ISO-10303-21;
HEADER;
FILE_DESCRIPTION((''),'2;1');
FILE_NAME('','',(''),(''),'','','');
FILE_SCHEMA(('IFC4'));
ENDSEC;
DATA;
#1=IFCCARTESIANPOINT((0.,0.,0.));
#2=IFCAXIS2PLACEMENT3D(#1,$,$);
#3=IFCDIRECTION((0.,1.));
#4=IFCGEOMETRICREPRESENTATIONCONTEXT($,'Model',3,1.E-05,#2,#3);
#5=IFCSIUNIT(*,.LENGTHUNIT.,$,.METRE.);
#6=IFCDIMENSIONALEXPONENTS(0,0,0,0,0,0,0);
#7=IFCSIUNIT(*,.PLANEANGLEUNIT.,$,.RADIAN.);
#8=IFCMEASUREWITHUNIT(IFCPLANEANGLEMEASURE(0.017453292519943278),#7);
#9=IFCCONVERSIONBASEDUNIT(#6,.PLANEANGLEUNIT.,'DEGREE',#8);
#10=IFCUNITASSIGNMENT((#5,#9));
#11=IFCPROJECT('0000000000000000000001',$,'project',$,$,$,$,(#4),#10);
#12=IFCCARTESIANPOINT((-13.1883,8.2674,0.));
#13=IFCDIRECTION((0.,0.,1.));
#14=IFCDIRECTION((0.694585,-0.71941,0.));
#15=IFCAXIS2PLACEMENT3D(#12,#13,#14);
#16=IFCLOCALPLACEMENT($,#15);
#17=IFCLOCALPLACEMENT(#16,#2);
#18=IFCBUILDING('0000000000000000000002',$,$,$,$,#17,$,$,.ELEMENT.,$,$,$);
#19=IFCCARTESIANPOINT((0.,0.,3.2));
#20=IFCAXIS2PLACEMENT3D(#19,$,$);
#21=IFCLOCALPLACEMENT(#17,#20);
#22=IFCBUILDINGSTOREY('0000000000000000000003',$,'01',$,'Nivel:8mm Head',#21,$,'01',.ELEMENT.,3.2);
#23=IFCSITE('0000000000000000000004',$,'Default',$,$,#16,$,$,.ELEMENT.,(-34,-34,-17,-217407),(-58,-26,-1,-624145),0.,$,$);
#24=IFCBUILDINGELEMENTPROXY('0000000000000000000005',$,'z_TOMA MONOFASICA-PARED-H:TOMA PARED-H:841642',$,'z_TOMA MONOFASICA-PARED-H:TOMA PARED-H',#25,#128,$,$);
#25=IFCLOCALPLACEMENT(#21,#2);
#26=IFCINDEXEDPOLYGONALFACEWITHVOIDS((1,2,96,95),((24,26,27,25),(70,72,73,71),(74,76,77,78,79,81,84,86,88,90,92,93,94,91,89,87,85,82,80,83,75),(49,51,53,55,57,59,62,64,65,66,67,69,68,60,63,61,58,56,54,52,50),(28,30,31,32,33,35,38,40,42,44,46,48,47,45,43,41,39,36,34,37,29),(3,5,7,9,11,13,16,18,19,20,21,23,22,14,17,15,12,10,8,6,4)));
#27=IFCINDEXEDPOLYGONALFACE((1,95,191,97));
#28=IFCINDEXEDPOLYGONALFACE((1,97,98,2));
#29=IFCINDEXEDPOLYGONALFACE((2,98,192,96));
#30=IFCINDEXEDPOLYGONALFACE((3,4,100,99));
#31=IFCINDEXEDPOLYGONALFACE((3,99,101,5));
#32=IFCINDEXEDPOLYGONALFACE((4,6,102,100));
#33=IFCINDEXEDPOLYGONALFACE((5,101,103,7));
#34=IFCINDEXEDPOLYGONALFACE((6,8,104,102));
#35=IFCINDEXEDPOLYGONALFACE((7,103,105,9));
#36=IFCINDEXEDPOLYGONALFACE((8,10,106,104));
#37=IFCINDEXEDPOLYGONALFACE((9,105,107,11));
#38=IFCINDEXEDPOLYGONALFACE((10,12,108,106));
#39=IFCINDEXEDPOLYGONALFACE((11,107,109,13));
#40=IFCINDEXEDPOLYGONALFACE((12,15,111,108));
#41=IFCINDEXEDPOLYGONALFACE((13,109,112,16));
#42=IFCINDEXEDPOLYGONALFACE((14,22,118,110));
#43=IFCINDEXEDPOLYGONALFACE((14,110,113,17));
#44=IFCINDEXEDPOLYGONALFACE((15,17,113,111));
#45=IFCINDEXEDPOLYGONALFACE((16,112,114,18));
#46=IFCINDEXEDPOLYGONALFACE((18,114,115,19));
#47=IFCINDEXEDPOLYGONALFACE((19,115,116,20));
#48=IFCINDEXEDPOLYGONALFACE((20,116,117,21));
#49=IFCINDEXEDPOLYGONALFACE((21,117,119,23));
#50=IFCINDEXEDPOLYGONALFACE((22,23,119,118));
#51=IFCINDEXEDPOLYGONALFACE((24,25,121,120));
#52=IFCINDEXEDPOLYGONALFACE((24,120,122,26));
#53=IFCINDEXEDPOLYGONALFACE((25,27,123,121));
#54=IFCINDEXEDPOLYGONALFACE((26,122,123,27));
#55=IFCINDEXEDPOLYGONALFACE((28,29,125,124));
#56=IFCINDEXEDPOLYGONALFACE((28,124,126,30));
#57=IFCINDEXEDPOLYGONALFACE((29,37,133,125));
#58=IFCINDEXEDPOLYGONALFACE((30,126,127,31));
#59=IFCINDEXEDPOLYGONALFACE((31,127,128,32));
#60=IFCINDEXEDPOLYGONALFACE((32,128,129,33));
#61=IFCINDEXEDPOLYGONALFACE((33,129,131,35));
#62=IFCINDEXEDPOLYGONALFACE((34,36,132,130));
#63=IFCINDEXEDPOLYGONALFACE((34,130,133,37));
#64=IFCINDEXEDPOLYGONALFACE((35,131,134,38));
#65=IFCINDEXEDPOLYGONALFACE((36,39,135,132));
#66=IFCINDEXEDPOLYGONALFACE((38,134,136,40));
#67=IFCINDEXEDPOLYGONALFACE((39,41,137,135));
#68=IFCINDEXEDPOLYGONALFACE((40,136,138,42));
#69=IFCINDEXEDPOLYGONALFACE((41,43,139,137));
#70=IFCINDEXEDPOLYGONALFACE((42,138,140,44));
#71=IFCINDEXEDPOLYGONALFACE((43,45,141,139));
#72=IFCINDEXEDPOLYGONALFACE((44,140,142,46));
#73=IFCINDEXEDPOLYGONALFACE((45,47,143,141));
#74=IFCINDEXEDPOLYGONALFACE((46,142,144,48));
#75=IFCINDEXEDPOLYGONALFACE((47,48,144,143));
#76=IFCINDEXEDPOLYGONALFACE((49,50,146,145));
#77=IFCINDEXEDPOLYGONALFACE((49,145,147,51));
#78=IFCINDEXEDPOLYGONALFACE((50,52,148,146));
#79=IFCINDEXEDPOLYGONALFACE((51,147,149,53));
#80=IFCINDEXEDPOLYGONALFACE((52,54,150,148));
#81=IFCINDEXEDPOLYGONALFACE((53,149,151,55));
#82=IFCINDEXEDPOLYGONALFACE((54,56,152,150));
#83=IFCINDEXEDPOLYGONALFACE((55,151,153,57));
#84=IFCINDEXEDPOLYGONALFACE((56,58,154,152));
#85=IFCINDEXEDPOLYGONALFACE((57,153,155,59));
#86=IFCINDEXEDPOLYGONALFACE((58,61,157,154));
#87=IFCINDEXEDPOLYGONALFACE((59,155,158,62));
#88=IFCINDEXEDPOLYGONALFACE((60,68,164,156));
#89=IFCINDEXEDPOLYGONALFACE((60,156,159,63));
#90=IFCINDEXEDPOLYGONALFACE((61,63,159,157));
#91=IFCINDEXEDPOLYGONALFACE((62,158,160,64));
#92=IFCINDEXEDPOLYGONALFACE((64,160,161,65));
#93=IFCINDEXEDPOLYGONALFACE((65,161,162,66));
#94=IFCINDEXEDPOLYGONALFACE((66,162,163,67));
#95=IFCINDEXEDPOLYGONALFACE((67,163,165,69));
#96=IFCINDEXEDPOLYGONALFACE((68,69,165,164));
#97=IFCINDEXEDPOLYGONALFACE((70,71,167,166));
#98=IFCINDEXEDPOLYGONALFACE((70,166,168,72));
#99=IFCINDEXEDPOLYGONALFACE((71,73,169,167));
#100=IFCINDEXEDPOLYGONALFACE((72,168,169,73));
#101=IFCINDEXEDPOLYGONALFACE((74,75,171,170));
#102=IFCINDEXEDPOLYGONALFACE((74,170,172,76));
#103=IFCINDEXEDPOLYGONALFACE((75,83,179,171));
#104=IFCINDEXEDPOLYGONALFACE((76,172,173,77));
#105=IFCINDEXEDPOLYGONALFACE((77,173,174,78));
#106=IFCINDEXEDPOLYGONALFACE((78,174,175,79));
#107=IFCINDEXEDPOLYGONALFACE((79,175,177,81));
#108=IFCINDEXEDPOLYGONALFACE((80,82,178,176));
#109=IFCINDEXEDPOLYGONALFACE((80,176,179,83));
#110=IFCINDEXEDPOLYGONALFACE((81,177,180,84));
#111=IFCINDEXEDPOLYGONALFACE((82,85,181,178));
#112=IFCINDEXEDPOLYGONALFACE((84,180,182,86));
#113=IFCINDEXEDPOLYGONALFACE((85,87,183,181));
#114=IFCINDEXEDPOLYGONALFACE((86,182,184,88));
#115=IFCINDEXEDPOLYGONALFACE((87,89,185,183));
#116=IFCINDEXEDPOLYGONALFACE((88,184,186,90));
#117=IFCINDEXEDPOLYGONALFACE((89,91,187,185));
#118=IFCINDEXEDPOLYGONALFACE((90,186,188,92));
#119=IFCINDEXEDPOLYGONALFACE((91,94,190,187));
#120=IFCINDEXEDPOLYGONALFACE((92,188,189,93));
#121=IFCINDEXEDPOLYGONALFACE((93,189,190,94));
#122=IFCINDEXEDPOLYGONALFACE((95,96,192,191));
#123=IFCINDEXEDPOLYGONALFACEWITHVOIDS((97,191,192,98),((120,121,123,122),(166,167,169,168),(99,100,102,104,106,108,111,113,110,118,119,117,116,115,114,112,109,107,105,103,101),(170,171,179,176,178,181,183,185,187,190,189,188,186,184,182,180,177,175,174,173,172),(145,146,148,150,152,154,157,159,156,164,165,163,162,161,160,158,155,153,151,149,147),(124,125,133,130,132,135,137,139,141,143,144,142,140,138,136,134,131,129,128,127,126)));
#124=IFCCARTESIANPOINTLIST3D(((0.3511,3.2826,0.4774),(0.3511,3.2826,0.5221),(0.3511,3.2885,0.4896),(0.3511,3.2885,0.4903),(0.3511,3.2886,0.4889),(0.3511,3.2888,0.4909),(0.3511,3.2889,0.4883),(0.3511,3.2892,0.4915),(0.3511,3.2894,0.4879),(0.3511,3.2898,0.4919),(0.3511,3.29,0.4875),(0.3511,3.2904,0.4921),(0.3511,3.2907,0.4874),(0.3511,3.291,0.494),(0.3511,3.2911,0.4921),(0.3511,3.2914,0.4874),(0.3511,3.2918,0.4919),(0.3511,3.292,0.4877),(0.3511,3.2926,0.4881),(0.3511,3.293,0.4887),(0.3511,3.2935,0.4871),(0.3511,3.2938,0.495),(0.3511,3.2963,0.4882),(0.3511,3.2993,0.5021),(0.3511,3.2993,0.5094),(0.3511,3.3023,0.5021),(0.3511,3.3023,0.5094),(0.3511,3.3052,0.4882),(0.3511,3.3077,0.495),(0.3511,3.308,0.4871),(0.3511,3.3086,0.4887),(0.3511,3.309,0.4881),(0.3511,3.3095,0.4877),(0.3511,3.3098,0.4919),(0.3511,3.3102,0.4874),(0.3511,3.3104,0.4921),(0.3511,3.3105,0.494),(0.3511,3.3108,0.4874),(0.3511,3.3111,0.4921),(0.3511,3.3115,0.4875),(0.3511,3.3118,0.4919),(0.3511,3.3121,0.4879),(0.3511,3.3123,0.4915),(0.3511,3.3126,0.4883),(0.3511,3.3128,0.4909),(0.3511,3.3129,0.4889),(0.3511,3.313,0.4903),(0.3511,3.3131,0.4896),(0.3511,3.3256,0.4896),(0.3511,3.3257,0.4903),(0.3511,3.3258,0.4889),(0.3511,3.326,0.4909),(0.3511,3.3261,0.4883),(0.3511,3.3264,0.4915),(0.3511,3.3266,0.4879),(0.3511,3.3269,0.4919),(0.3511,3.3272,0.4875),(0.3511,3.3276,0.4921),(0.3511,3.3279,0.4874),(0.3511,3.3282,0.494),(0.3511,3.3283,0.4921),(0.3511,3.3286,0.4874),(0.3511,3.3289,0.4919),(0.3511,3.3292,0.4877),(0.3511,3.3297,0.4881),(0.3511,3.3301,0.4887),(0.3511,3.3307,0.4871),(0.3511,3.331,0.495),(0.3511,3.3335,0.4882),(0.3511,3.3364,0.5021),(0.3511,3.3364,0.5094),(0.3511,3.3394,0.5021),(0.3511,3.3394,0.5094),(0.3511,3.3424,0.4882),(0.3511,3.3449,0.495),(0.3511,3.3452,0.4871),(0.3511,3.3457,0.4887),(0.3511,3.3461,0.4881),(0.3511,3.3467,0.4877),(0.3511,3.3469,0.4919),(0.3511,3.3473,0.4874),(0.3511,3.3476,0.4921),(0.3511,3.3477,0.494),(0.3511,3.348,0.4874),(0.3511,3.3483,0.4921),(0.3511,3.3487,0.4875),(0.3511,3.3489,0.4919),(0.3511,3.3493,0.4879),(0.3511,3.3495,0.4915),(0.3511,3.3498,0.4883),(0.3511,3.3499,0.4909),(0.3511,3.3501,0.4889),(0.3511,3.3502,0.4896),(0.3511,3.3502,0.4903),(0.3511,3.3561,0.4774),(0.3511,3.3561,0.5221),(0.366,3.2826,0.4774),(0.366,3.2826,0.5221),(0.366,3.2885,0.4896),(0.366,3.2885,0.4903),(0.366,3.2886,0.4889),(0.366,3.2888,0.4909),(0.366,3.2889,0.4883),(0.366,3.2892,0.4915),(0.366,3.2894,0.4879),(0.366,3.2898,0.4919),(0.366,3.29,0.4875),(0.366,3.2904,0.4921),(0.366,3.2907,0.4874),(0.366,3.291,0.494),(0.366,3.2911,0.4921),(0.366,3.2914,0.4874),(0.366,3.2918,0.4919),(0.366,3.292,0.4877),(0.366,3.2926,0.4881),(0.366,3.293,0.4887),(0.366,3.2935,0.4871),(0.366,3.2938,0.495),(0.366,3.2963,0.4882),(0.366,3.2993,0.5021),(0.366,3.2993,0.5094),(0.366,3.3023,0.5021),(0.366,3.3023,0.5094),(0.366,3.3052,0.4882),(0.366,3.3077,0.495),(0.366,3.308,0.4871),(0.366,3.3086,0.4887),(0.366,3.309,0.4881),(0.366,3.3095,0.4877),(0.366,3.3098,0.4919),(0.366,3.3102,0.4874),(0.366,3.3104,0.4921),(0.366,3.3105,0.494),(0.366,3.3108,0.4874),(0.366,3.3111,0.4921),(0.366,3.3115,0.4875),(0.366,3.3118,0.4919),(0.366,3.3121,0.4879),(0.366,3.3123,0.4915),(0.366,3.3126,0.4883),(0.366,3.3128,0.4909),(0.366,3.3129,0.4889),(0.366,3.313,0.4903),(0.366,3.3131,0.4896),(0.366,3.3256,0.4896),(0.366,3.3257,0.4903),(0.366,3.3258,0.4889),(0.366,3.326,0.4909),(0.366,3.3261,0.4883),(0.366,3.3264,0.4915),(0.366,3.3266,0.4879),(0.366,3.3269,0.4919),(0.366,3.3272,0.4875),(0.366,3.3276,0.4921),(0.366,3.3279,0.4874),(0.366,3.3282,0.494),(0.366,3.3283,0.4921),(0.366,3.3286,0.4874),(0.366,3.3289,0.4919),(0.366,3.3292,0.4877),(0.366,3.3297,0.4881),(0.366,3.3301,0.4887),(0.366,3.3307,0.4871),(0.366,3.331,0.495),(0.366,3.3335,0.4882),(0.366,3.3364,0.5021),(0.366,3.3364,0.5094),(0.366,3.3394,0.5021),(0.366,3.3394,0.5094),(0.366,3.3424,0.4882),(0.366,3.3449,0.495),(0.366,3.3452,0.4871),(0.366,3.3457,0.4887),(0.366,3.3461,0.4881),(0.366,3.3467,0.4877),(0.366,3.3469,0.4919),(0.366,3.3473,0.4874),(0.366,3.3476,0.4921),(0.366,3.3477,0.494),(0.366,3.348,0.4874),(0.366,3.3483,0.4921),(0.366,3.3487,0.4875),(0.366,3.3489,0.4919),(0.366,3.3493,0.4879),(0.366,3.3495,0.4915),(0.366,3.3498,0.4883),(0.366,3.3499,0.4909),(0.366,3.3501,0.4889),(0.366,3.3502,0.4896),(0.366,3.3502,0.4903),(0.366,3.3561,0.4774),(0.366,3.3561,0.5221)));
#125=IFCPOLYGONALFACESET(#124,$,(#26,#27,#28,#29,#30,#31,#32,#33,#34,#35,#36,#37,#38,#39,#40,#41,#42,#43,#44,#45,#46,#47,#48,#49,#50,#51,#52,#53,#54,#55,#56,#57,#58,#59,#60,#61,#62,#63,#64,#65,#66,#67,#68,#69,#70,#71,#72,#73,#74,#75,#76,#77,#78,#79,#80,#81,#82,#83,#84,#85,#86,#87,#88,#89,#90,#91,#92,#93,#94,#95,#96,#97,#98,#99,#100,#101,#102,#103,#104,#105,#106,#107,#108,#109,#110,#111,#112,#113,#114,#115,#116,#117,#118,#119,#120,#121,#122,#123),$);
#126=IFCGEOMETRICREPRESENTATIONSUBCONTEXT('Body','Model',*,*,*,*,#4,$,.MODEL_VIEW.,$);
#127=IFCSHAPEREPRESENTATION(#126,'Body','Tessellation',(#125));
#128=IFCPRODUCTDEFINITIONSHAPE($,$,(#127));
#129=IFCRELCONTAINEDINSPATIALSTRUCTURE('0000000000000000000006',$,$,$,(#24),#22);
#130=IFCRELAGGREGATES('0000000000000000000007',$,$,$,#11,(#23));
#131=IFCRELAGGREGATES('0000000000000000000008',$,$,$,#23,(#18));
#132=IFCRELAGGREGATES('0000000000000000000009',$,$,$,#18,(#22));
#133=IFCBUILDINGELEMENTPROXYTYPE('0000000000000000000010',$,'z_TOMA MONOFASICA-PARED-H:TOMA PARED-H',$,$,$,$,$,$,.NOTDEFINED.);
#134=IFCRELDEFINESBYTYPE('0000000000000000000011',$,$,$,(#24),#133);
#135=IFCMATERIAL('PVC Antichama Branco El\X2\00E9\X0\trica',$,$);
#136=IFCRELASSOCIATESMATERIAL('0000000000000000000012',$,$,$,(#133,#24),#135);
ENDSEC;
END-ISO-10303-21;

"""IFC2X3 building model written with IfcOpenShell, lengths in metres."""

from ifc_helpers import new_model, entity, si_unit, converted_unit, direction, frame, frame_2d, origin, place, context, subcontext, project, spatial, polyline, circle_curve, parameter, trimmed, segment, composite_curve, outline, extrude, source, transform, mapped, material, type_object, type_shapes, element, save


model = new_model("IFC2X3")

# Units and contexts
model_context = context("Model", 3, precision=1e-05, world=origin(), true_north=direction((0.0, 1.0)))
body_context = subcontext(model_context, "Body", "Model", "MODEL_VIEW")
ifc_project = project(units=[si_unit("LENGTHUNIT", "METRE"), converted_unit("PLANEANGLEUNIT", "DEGREE", entity("IfcPlaneAngleMeasure", 0.017453292519943278), si_unit("PLANEANGLEUNIT", "RADIAN"), dimensions=[0, 0, 0, 0, 0, 0, 0])], contexts=[model_context])

# Site, building, storey
site_placement = place(None, frame((-13.1883, 8.2674, 0.0), z_axis=(0.0, 0.0, 1.0), x_axis=(0.694585, -0.71941, 0.0)))
site = spatial("IfcSite", under=ifc_project, at=site_placement, Name="Default", CompositionType="ELEMENT", RefLatitude=(-34, -34, -17, -217407), RefLongitude=(-58, -26, -1, -624145), RefElevation=0.0)
building_placement = place(site_placement, origin())
building = spatial("IfcBuilding", under=site, at=building_placement, CompositionType="ELEMENT")
storey_placement = place(building_placement, frame((0.0, 0.0, 3.2)))
storey = spatial("IfcBuildingStorey", under=building, at=storey_placement, Name="01", ObjectType="Nivel:8mm Head", LongName="01", CompositionType="ELEMENT", Elevation=3.2)

# Building element proxy
ifc_material_1 = material(Name="PVC Antichama Branco Elétrica")
building_element_proxy_type_1 = type_object("IfcBuildingElementProxyType", Name="z_TOMA MONOFASICA-PARED-H:TOMA PARED-H", PredefinedType="NOTDEFINED", material=ifc_material_1)
shared_shape_1 = source(origin(), body_context, "Body", "SweptSolid", [
    extrude(outline(polyline([(-0.0368, -0.0223), (0.0368, -0.0223), (0.0368, 0.0223), (-0.0368, 0.0223), (-0.0368, -0.0223)]), holes=[composite_curve([segment(polyline([(0.0141, 0.0115), (0.0116, 0.0047)]), True, "CONTINUOUS"), segment(polyline([(0.0116, 0.0047), (0.0088, 0.0057)]), True, "CONTINUOUS"), segment(polyline([(0.0088, 0.0057), (0.0096, 0.0078)]), True, "CONTINUOUS"), segment(trimmed(circle_curve(frame_2d((0.0087, 0.0099), x_axis=(1.0, 0.0)), 0.0024), [parameter(27.118901)], [parameter(292.881099)], True, "PARAMETER"), False, "CONTINUOUS"), segment(polyline([(0.0108, 0.011), (0.0113, 0.0126)]), True, "CONTINUOUS"), segment(polyline([(0.0113, 0.0126), (0.0141, 0.0115)]), True, "CONTINUOUS")], self_intersect=False), composite_curve([segment(polyline([(0.0255, 0.0047), (0.023, 0.0115)]), True, "CONTINUOUS"), segment(polyline([(0.023, 0.0115), (0.0258, 0.0126)]), True, "CONTINUOUS"), segment(polyline([(0.0258, 0.0126), (0.0264, 0.011)]), True, "CONTINUOUS"), segment(trimmed(circle_curve(frame_2d((0.0285, 0.0099), x_axis=(1.0, 0.0)), 0.0024), [parameter(247.118901)], [parameter(152.881099)], True, "PARAMETER"), False, "CONTINUOUS"), segment(polyline([(0.0276, 0.0078), (0.0283, 0.0057)]), True, "CONTINUOUS"), segment(polyline([(0.0283, 0.0057), (0.0255, 0.0047)]), True, "CONTINUOUS")], self_intersect=False), polyline([(0.0201, -0.0024), (0.0201, -0.0097), (0.0171, -0.0097), (0.0171, -0.0024), (0.0201, -0.0024)]), composite_curve([segment(polyline([(-0.0141, 0.0115), (-0.0113, 0.0126)]), True, "CONTINUOUS"), segment(polyline([(-0.0113, 0.0126), (-0.0108, 0.011)]), True, "CONTINUOUS"), segment(trimmed(circle_curve(frame_2d((-0.0087, 0.0099), x_axis=(1.0, 0.0)), 0.0024), [parameter(247.118901)], [parameter(152.881099)], True, "PARAMETER"), False, "CONTINUOUS"), segment(polyline([(-0.0096, 0.0078), (-0.0088, 0.0057)]), True, "CONTINUOUS"), segment(polyline([(-0.0088, 0.0057), (-0.0116, 0.0047)]), True, "CONTINUOUS"), segment(polyline([(-0.0116, 0.0047), (-0.0141, 0.0115)]), True, "CONTINUOUS")], self_intersect=False), composite_curve([segment(polyline([(-0.0255, 0.0047), (-0.0283, 0.0057)]), True, "CONTINUOUS"), segment(polyline([(-0.0283, 0.0057), (-0.0276, 0.0078)]), True, "CONTINUOUS"), segment(trimmed(circle_curve(frame_2d((-0.0285, 0.0099), x_axis=(1.0, 0.0)), 0.0024), [parameter(27.118901)], [parameter(292.881099)], True, "PARAMETER"), False, "CONTINUOUS"), segment(polyline([(-0.0264, 0.011), (-0.0258, 0.0126)]), True, "CONTINUOUS"), segment(polyline([(-0.0258, 0.0126), (-0.023, 0.0115)]), True, "CONTINUOUS"), segment(polyline([(-0.023, 0.0115), (-0.0255, 0.0047)]), True, "CONTINUOUS")], self_intersect=False), polyline([(-0.0201, -0.0024), (-0.0171, -0.0024), (-0.0171, -0.0097), (-0.0201, -0.0097), (-0.0201, -0.0024)])]), frame((0.0, -0.005, 0.0223), z_axis=(0.0, 1.0, 0.0), x_axis=(1.0, 0.0, 0.0)), (0.0, 0.0, 1.0), 0.0148),
])
type_shapes(building_element_proxy_type_1, [shared_shape_1])
for number, where, z_axis, x_axis, name in (
    (1, (0.361, 3.3194, 0.4774), (0.0, 0.0, 1.0), (0.0, 1.0, 0.0), "z_TOMA MONOFASICA-PARED-H:TOMA PARED-H:841642"),
):
    element("IfcBuildingElementProxy", number, at=place(storey_placement, frame(where, z_axis=z_axis, x_axis=x_axis)), inside=storey, type_object=building_element_proxy_type_1, material=ifc_material_1, Name=name, ObjectType="z_TOMA MONOFASICA-PARED-H:TOMA PARED-H", context=body_context, shape_type="MappedRepresentation", body=[
        mapped(shared_shape_1, transform((0.0, 0.0, 0.0), scale=1.0)),
    ])

save(model, "model.ifc")
